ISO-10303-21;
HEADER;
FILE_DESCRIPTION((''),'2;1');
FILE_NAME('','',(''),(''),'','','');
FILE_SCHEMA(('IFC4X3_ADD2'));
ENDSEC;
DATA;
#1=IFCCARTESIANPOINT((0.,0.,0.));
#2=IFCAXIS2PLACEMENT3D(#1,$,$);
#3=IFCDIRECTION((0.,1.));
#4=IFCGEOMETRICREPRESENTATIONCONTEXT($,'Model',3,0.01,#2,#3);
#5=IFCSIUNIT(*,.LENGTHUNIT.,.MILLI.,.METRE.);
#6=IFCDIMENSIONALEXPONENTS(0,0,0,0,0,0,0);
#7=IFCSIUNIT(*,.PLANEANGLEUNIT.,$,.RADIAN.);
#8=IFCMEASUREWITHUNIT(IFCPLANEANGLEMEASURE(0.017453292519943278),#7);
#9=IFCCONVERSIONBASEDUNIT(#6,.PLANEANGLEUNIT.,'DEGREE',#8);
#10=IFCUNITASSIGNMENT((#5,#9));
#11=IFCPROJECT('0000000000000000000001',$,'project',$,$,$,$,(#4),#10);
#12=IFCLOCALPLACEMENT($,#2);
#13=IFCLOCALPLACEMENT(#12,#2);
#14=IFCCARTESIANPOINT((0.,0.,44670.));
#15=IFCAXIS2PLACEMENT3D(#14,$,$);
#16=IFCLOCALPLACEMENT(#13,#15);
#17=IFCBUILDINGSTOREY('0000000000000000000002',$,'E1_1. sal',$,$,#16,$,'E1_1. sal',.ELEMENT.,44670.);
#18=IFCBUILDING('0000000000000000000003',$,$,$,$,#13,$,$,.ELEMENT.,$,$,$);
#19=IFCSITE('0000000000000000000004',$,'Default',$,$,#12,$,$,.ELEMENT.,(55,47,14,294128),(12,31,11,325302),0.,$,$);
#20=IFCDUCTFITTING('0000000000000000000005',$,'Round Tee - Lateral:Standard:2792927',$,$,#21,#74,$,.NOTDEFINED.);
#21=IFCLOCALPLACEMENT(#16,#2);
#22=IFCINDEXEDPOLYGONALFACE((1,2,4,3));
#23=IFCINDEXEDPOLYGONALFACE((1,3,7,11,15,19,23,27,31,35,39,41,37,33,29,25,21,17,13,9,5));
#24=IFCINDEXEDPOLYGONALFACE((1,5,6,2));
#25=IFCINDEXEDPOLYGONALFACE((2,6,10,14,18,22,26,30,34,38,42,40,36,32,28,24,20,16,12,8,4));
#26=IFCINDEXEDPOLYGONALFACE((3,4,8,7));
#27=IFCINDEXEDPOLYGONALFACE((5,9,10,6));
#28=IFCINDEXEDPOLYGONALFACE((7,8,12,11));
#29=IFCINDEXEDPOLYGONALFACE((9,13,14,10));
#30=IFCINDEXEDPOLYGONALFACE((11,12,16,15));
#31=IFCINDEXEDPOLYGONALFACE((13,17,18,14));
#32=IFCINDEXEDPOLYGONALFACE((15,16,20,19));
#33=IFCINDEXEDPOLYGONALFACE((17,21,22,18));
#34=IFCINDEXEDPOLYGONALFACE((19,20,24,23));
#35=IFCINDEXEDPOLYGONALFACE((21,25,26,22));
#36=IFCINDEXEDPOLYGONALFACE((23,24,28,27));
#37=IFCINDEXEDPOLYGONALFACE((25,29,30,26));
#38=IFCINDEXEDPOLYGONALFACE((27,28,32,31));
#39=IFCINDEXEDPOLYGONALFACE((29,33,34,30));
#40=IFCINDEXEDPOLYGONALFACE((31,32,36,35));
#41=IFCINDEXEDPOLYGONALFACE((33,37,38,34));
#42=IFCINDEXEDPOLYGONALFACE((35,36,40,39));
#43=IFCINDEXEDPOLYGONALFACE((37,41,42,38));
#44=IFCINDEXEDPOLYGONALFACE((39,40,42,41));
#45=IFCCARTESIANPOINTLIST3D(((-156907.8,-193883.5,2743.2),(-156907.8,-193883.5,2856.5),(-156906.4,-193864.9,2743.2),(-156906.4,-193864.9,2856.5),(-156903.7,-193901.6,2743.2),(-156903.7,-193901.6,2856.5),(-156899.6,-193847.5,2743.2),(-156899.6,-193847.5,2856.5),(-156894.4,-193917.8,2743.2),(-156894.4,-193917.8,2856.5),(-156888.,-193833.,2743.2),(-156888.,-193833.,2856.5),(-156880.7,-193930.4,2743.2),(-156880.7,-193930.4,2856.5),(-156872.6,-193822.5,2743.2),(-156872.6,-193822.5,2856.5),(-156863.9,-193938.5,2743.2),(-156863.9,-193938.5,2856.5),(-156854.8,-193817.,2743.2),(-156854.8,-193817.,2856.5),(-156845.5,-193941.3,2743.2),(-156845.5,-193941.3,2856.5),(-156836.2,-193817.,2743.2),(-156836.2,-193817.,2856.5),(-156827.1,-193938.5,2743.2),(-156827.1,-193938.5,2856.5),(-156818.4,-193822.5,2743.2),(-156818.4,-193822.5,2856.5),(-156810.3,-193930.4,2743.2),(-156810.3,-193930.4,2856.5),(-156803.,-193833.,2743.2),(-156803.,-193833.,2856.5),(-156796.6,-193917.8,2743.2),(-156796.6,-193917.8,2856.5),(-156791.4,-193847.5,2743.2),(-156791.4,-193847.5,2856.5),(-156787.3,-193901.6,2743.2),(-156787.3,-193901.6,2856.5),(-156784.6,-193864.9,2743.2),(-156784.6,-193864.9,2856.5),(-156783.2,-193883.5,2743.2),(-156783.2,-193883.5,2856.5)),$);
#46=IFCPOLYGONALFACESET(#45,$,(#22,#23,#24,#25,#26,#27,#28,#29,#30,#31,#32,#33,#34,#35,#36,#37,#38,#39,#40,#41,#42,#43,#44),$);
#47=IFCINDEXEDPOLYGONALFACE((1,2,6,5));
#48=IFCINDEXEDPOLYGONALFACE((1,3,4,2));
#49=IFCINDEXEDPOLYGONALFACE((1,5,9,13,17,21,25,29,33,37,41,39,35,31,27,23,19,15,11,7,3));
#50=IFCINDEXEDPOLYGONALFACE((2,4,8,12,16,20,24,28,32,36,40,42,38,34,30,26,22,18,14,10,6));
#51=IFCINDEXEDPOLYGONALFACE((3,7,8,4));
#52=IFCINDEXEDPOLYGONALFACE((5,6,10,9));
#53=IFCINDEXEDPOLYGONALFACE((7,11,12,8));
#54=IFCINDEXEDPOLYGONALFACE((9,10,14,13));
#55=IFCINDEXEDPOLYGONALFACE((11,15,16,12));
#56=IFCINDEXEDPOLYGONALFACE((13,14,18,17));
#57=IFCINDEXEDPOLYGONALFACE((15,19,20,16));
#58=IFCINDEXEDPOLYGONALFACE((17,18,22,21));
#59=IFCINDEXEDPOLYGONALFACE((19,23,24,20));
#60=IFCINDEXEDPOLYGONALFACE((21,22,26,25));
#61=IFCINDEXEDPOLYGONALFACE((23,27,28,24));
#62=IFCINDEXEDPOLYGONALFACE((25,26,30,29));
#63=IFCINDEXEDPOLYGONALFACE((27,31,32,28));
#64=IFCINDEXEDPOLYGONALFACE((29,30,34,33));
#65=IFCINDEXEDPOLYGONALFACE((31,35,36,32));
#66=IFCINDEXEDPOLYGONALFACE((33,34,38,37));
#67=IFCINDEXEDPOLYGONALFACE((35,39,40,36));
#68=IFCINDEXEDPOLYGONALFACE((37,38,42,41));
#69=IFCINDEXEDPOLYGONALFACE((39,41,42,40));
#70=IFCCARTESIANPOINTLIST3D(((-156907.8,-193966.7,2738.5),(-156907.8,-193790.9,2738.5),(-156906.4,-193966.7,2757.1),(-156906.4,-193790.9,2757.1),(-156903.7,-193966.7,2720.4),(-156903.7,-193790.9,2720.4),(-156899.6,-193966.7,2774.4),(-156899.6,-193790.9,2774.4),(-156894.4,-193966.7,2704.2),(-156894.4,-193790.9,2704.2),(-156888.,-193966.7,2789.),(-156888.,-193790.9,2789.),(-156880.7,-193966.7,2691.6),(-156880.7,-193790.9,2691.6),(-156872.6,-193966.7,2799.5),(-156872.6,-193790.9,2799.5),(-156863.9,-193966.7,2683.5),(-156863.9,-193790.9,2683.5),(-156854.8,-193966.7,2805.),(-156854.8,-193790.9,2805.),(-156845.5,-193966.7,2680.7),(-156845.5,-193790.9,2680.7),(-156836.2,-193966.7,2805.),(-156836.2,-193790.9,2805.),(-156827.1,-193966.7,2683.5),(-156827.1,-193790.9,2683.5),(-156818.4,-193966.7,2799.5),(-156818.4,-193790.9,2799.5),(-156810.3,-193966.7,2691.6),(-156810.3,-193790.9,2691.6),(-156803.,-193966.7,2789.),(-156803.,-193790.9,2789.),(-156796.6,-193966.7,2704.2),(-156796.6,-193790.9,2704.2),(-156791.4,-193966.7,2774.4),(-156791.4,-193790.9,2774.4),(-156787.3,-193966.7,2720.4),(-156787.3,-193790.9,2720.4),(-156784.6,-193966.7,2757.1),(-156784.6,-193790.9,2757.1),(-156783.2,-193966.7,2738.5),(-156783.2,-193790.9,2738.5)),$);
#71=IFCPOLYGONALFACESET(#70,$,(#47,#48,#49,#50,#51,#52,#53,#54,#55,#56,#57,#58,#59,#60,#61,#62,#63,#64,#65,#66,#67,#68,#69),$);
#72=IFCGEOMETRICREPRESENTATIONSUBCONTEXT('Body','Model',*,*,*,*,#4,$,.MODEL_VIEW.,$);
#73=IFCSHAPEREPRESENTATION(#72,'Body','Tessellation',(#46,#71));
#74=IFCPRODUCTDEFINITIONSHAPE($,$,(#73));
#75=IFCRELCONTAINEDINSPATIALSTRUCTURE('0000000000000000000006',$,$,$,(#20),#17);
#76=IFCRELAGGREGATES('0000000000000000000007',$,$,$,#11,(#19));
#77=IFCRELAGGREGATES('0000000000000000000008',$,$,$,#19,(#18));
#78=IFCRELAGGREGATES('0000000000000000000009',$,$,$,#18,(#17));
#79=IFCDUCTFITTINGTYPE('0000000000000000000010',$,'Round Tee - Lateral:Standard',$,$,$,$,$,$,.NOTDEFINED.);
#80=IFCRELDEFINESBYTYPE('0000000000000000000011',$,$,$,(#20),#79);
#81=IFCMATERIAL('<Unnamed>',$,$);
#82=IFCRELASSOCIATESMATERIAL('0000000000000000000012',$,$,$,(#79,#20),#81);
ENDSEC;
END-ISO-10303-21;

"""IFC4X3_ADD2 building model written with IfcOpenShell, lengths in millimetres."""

from ifc_helpers import new_model, entity, si_unit, converted_unit, direction, frame, frame_2d, origin, place, context, subcontext, project, spatial, circle, extrude, source, transform, mapped, material, type_object, type_shapes, element, save


model = new_model("IFC4X3_ADD2")

# Units and contexts
model_context = context("Model", 3, precision=0.01, world=origin(), true_north=direction((0.0, 1.0)))
body_context = subcontext(model_context, "Body", "Model", "MODEL_VIEW")
ifc_project = project(units=[si_unit("LENGTHUNIT", "METRE", prefix="MILLI"), converted_unit("PLANEANGLEUNIT", "DEGREE", entity("IfcPlaneAngleMeasure", 0.017453292519943278), si_unit("PLANEANGLEUNIT", "RADIAN"), dimensions=[0, 0, 0, 0, 0, 0, 0])], contexts=[model_context])

# Site, building, storey
site_placement = place(None, origin())
site = spatial("IfcSite", under=ifc_project, at=site_placement, Name="Default", CompositionType="ELEMENT", RefLatitude=(55, 47, 14, 294128), RefLongitude=(12, 31, 11, 325302), RefElevation=0.0)
building_placement = place(site_placement, origin())
building = spatial("IfcBuilding", under=site, at=building_placement, CompositionType="ELEMENT")
storey_placement = place(building_placement, frame((0.0, 0.0, 44670.0)))
storey = spatial("IfcBuildingStorey", under=building, at=storey_placement, Name="E1_1. sal", LongName="E1_1. sal", CompositionType="ELEMENT", Elevation=44670.0)

# Shared definitions
ifc_material_1 = material(Name="<Unnamed>")

# Duct fitting
duct_fitting_type = type_object("IfcDuctFittingType", Name="Round Tee - Lateral:Standard", PredefinedType="NOTDEFINED", material=ifc_material_1)
shared_shape_1 = source(origin(), body_context, "Body", "SweptSolid", [
    extrude(circle(Radius=62.5, at=frame_2d((0.0, 0.0), x_axis=(1.0, 0.0))), frame((0.0, -113.3, 0.0), z_axis=(0.0, 1.0, 0.0), x_axis=(1.0, 0.0, 0.0)), (0.0, 0.0, 1.0), 113.3),
    extrude(circle(Radius=62.5, at=frame_2d((0.0, 0.0), x_axis=(1.0, 0.0))), frame((-87.9, 0.0, 0.0), z_axis=(1.0, 0.0, 0.0), x_axis=(0.0, 1.0, 0.0)), (0.0, 0.0, 1.0), 175.8),
])
type_shapes(duct_fitting_type, [shared_shape_1])
for number, where, z_axis, x_axis, name in (
    (1, (-156845.5, -193878.8, 2743.2), (1.0, 0.0, 0.0), (0.0, -1.0, 0.0), "Round Tee - Lateral:Standard:2792927"),
):
    element("IfcDuctFitting", number, at=place(storey_placement, frame(where, z_axis=z_axis, x_axis=x_axis)), inside=storey, type_object=duct_fitting_type, material=ifc_material_1, Name=name, PredefinedType="NOTDEFINED", context=body_context, shape_type="MappedRepresentation", body=[
        mapped(shared_shape_1, transform((0.0, 0.0, 0.0), scale=1.0)),
    ])

save(model, "model.ifc")
